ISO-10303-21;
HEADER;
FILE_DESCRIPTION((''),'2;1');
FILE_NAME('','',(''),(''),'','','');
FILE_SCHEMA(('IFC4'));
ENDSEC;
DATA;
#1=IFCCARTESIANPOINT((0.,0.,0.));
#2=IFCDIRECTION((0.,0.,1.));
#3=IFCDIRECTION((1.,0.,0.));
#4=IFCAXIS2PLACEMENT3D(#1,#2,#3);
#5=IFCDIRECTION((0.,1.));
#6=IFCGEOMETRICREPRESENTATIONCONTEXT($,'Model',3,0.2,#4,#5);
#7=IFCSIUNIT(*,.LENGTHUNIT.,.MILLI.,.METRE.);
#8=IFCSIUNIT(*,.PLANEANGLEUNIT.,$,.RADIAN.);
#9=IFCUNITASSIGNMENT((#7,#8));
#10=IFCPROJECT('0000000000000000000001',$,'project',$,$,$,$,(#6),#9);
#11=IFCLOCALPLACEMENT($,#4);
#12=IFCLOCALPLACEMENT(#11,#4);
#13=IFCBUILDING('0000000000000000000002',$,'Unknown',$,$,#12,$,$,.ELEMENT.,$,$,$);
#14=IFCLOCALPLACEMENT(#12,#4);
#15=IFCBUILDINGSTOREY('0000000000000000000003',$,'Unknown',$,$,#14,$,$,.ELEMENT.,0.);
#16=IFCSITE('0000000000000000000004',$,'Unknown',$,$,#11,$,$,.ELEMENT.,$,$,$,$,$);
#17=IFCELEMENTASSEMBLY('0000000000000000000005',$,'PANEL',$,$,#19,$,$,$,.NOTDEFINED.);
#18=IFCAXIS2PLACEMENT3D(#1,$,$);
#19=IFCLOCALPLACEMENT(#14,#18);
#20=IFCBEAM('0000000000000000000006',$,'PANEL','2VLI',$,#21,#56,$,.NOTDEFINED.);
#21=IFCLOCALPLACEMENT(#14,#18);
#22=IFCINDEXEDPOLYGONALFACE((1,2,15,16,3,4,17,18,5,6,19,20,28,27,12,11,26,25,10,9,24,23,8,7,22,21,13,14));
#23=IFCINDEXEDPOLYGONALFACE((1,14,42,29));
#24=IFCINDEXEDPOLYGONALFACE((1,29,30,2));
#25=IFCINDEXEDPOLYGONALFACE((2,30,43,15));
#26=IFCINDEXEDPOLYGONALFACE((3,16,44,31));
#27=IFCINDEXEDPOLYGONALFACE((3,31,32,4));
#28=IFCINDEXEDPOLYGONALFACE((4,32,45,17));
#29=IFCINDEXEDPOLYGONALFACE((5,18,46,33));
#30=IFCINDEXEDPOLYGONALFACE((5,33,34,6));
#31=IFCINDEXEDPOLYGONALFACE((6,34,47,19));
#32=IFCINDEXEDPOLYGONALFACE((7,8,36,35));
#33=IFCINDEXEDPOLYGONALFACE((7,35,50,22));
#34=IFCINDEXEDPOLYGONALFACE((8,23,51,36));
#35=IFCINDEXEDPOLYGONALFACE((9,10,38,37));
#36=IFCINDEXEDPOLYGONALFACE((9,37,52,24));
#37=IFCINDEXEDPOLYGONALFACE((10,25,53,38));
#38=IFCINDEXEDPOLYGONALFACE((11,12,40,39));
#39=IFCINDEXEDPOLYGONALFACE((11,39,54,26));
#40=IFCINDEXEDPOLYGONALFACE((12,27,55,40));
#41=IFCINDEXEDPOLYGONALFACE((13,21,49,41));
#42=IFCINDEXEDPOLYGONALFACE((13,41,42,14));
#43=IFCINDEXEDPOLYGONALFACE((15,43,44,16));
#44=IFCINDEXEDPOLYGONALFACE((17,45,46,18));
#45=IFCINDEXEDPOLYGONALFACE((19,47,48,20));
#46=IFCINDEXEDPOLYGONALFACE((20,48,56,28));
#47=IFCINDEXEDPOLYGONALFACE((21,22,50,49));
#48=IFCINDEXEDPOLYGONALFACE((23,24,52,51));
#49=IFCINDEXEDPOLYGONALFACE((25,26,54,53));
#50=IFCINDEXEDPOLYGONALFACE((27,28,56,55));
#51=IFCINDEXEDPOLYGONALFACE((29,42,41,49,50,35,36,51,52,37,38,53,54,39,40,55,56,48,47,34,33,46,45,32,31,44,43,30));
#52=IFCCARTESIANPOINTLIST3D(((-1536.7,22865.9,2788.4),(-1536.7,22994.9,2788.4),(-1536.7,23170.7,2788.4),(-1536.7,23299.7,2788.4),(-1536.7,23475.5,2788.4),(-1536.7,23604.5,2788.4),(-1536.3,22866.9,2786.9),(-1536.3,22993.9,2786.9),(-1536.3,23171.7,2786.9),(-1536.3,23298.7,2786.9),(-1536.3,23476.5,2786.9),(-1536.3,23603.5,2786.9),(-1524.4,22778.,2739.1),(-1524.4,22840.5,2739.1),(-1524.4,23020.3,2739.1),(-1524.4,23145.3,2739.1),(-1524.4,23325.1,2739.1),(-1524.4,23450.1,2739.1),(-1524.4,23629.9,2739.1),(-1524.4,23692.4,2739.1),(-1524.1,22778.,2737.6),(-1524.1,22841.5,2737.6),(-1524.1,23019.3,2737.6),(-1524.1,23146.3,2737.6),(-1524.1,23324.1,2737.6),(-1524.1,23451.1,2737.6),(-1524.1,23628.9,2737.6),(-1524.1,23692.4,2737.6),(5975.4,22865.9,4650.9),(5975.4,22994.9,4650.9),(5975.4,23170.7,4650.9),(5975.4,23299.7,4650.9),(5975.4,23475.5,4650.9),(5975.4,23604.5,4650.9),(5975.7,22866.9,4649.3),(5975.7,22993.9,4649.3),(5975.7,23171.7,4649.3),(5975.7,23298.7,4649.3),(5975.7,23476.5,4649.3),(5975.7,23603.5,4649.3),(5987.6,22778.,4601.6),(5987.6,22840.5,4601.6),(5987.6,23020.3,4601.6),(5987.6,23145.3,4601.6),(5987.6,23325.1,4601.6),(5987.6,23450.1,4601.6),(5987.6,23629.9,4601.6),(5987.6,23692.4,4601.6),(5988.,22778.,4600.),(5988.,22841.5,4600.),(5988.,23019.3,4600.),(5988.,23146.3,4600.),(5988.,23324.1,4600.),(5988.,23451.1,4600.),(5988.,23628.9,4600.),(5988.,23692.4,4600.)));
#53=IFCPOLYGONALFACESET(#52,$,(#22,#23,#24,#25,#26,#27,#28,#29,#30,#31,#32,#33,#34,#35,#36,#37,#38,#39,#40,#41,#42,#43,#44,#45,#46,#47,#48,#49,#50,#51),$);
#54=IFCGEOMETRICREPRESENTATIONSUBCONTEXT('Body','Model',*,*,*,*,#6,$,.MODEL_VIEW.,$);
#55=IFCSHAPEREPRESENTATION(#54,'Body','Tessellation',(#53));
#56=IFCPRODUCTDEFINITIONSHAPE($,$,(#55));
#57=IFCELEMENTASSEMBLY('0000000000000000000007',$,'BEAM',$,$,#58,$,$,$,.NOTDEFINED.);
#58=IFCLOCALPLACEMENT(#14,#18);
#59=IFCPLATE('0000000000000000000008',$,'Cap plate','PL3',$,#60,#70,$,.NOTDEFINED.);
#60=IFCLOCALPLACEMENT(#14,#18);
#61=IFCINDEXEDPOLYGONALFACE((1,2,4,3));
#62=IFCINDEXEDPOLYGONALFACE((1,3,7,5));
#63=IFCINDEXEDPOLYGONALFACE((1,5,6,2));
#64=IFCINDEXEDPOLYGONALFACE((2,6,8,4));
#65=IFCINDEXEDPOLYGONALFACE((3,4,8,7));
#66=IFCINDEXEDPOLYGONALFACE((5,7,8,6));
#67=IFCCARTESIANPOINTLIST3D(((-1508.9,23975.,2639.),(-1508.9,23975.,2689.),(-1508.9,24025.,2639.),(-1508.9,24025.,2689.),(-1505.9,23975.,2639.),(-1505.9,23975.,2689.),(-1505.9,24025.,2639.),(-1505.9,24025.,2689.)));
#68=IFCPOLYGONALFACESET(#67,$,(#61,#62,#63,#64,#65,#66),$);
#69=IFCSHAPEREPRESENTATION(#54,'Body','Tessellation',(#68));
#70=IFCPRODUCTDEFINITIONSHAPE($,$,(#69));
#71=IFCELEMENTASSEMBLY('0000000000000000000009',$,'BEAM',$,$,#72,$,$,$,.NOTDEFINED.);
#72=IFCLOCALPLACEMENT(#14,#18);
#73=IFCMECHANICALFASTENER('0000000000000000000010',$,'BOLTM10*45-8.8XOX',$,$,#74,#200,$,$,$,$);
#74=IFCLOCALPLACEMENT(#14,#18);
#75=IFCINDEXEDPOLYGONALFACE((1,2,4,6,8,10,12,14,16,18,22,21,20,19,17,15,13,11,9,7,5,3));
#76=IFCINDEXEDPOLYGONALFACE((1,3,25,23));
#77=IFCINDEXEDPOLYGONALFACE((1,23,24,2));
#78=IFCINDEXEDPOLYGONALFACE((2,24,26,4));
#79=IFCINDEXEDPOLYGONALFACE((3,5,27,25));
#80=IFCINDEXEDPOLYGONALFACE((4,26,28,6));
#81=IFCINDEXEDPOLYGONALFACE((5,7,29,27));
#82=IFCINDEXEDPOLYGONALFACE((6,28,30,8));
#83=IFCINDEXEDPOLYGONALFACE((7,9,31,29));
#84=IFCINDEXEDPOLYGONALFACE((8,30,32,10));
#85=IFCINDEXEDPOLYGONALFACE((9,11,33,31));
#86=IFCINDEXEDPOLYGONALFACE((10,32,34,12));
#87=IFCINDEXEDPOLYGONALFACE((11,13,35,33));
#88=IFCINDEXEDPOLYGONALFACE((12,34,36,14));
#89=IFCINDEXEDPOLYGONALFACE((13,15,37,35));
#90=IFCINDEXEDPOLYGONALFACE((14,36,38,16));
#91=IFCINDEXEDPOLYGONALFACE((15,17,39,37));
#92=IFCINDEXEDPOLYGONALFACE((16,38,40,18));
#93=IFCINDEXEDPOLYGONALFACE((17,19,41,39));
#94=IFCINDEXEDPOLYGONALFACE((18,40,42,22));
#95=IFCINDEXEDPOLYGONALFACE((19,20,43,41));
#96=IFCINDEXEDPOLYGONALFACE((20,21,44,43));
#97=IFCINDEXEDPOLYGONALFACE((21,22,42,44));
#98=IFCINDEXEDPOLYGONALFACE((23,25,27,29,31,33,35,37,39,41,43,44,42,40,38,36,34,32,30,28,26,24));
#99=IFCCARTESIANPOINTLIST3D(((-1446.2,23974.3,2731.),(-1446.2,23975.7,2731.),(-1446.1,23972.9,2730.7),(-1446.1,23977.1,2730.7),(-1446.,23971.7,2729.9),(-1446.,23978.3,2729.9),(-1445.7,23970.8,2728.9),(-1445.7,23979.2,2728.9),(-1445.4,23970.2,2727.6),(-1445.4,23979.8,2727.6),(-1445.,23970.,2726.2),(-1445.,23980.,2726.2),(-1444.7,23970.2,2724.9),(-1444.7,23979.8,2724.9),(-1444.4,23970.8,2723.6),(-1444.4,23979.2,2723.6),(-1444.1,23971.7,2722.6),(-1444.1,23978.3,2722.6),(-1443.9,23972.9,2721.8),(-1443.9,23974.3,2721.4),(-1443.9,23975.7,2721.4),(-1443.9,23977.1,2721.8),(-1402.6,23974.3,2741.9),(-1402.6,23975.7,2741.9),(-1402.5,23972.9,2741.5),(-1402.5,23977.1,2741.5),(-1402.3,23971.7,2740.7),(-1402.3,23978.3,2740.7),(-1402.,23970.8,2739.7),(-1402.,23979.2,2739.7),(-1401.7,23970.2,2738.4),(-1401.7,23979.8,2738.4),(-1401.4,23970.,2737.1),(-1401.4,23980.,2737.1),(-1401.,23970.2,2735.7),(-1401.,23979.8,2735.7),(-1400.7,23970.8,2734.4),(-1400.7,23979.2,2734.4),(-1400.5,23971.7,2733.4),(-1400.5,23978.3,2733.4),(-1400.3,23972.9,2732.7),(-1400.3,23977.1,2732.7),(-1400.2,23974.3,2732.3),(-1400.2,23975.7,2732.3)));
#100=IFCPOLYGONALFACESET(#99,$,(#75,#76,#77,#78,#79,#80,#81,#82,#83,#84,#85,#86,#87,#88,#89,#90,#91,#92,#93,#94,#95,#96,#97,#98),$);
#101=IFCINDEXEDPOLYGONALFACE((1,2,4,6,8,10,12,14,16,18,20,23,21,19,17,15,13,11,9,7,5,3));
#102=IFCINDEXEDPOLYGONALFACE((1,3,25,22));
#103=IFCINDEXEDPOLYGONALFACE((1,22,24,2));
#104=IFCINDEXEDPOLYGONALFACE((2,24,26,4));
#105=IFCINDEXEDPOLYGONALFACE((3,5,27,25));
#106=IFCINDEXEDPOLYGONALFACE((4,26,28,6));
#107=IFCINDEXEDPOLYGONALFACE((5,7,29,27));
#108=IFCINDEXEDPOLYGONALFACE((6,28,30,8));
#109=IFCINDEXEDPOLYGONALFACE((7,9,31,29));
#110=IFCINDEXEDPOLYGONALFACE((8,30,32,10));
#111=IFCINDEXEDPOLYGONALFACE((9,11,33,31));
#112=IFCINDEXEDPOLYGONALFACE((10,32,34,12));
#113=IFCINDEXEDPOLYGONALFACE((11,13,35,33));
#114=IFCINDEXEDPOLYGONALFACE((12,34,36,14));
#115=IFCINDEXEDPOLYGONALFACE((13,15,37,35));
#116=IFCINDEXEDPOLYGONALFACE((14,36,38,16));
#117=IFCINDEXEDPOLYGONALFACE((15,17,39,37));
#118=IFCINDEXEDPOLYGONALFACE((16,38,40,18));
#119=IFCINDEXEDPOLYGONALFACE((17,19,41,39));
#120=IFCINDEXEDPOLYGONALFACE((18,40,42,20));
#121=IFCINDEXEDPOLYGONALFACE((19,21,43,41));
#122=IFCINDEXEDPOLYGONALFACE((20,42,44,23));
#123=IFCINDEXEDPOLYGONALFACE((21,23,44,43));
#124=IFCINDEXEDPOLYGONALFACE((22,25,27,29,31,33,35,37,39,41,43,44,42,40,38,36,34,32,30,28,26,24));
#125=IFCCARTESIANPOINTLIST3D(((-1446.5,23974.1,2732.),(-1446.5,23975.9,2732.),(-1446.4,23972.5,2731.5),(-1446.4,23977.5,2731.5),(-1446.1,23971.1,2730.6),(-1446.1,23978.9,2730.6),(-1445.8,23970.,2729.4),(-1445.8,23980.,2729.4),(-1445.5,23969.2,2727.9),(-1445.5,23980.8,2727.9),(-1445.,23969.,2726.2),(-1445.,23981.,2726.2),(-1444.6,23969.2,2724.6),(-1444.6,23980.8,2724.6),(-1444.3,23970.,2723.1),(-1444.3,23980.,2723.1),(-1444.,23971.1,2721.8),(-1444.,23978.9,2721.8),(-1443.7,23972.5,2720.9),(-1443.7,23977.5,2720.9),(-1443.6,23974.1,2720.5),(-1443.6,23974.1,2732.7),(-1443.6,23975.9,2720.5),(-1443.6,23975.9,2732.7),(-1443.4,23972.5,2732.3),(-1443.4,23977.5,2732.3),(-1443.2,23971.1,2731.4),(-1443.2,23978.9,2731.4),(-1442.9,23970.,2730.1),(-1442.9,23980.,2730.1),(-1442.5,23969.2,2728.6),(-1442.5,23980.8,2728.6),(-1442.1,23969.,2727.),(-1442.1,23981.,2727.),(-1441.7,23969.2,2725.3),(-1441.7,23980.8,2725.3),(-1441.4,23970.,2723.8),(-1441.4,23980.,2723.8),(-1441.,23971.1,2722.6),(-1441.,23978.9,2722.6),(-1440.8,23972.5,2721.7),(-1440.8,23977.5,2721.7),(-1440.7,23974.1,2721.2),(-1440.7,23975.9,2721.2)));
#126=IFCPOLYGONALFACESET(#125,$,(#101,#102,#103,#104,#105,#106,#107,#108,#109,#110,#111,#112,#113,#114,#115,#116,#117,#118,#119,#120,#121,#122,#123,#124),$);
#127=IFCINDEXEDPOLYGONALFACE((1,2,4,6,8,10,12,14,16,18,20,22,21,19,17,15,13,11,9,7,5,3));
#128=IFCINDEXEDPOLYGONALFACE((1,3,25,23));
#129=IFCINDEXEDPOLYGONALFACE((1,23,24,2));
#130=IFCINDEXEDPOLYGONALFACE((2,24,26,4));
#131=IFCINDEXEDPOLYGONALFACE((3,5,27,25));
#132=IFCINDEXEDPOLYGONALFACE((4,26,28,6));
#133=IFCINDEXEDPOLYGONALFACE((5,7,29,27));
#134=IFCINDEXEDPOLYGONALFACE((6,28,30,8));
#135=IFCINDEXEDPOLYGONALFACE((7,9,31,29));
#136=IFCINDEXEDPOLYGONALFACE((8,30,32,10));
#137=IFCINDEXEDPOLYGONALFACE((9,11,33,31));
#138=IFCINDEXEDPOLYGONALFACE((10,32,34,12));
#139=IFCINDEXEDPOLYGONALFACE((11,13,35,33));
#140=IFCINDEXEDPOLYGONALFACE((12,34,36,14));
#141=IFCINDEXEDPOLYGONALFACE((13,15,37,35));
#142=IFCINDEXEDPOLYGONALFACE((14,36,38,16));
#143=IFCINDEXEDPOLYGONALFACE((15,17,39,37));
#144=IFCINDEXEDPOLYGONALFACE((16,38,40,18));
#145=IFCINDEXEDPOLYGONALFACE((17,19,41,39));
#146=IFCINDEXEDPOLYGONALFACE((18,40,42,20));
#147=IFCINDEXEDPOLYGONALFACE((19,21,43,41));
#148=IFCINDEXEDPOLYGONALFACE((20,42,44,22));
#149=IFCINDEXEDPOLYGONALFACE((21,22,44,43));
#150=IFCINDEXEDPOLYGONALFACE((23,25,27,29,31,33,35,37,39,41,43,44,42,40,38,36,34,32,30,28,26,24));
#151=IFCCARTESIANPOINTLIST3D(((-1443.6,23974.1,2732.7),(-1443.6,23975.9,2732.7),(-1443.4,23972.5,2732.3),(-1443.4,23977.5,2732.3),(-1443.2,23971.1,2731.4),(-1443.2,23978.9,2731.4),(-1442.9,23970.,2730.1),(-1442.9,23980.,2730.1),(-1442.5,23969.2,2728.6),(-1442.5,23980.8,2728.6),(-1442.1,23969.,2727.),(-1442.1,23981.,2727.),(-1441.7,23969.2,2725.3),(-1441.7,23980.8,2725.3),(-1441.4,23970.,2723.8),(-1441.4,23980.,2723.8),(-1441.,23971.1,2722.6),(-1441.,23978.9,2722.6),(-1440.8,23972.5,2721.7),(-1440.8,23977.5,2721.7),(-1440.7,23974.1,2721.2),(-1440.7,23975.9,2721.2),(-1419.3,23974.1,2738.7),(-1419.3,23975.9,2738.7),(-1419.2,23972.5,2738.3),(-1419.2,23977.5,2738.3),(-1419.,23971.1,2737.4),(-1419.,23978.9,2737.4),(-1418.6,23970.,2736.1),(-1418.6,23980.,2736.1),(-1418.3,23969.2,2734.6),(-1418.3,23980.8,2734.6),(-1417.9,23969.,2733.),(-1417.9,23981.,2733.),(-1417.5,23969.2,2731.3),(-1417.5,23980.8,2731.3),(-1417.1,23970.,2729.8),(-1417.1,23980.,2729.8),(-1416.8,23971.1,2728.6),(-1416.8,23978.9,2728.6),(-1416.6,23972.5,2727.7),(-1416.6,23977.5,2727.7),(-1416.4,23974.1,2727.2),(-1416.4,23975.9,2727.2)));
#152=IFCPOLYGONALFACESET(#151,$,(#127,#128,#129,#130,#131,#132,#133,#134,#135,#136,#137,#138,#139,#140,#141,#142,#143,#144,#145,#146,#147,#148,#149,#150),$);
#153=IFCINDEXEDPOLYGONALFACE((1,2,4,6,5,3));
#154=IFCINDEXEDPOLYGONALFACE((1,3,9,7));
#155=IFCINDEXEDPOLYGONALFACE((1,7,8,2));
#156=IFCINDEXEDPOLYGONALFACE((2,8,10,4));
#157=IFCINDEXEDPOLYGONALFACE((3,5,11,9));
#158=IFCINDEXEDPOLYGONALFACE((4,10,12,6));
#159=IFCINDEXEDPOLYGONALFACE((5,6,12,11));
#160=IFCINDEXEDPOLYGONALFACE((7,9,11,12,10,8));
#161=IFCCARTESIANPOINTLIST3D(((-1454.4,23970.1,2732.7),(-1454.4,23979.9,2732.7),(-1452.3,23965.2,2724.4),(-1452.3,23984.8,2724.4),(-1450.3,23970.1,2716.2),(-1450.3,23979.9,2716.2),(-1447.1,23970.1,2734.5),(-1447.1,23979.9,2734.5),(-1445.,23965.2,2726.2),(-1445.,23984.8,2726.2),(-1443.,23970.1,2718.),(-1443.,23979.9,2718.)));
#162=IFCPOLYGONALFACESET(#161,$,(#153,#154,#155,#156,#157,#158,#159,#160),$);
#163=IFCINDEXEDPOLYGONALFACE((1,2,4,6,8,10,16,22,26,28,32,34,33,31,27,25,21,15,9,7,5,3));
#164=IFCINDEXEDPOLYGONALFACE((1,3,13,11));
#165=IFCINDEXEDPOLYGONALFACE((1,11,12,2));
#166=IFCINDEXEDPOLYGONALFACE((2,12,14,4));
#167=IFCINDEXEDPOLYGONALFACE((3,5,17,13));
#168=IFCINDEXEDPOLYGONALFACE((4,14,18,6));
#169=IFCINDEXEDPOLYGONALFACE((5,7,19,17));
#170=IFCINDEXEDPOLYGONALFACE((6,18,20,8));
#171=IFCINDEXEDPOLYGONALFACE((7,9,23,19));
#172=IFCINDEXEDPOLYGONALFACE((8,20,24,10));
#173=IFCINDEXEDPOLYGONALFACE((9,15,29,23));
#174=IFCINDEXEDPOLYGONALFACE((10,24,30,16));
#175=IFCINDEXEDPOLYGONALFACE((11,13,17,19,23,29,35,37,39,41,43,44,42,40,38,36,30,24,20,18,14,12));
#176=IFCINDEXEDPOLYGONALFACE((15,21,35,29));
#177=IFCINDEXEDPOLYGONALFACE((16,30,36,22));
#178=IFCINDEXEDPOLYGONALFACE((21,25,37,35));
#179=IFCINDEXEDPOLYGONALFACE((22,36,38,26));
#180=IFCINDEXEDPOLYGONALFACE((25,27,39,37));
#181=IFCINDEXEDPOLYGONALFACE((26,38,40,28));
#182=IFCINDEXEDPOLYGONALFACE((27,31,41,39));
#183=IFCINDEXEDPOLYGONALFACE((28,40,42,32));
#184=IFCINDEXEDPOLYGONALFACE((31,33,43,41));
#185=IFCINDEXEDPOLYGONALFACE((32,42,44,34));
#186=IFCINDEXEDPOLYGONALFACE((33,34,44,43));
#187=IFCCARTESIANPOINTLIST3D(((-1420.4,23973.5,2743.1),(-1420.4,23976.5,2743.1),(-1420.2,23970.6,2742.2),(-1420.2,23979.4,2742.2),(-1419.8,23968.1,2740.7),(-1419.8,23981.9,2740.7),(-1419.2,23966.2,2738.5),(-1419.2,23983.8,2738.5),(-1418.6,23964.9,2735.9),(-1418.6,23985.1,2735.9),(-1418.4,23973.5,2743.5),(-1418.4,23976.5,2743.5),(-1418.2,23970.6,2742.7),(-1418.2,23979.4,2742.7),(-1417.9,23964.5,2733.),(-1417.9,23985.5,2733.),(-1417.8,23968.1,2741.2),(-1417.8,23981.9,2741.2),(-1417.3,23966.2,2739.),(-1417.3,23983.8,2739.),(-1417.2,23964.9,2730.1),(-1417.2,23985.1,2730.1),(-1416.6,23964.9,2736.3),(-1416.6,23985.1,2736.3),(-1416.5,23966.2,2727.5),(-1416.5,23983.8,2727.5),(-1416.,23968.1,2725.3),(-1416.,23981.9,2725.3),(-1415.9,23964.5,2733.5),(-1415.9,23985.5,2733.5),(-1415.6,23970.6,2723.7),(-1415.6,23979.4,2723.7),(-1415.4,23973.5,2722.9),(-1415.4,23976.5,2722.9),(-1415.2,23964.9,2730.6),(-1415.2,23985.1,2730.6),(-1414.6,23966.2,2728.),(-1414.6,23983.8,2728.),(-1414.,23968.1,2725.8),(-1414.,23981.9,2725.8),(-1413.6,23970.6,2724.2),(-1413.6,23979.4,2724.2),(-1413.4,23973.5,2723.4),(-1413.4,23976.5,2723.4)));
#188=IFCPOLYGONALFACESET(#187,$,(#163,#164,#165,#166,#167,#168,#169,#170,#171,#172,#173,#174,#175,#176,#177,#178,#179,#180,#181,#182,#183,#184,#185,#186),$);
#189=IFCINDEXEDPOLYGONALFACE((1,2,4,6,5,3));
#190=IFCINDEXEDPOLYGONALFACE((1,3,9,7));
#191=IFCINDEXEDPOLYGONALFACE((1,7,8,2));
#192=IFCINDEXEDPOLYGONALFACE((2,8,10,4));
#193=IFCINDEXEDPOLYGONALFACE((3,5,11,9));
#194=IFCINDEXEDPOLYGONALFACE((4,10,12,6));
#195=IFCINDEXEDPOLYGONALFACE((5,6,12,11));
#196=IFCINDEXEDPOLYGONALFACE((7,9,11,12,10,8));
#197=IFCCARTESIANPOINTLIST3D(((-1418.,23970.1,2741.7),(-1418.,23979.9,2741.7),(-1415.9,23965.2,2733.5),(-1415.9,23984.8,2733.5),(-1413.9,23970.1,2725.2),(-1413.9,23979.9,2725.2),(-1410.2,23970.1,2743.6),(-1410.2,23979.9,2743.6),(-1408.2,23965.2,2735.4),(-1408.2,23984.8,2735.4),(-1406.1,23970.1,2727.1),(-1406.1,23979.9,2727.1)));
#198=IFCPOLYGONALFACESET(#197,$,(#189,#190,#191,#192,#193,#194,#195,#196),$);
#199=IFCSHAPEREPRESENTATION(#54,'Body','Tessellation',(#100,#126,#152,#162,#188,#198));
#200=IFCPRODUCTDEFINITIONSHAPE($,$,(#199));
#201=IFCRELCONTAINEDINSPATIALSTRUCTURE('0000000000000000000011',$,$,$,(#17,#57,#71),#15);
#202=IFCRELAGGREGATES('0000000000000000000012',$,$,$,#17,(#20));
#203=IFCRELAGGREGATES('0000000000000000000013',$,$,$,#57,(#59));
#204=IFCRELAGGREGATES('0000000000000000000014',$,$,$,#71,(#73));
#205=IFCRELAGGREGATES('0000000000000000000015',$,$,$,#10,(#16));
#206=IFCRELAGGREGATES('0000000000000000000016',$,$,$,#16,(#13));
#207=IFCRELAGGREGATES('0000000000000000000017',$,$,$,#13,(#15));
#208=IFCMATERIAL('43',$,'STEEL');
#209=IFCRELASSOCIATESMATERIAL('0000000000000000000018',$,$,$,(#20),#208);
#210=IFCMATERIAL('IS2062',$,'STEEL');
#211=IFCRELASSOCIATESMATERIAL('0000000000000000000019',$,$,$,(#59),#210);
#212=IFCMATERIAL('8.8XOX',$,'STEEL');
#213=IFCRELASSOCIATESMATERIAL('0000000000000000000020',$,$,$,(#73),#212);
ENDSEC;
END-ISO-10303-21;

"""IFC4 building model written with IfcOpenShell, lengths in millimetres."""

from ifc_helpers import new_model, si_unit, direction, frame, origin_with_axes, place, context, subcontext, project, spatial, line, arc, indexed_curve, outline, extrude, source, transform, mapped, material, element, aggregate, save


model = new_model("IFC4")

# Units and contexts
model_context = context("Model", 3, precision=0.2, world=origin_with_axes(), true_north=direction((0.0, 1.0)))
body_context = subcontext(model_context, "Body", "Model", "MODEL_VIEW")
ifc_project = project(units=[si_unit("LENGTHUNIT", "METRE", prefix="MILLI"), si_unit("PLANEANGLEUNIT", "RADIAN")], contexts=[model_context])

# Site, building, storey
site_placement = place(None, origin_with_axes())
site = spatial("IfcSite", under=ifc_project, at=site_placement, Name="Unknown", CompositionType="ELEMENT")
building_placement = place(site_placement, origin_with_axes())
building = spatial("IfcBuilding", under=site, at=building_placement, Name="Unknown", CompositionType="ELEMENT")
storey_placement = place(building_placement, origin_with_axes())
storey = spatial("IfcBuildingStorey", under=building, at=storey_placement, Name="Unknown", CompositionType="ELEMENT", Elevation=0.0)

# Shared definitions
ifc_material_1 = material(Name="IS2062", Category="STEEL")

# Element assembly, beam
ifc_material_2 = material(Name="43", Category="STEEL")
assembly_1_placement = place(storey_placement, frame((-1530.4, 23235.2, 2763.0), z_axis=(0.0, -1.0, 0.0), x_axis=(0.970613, 0.0, 0.240648)))
assembly_1 = element("IfcElementAssembly", 1, at=assembly_1_placement, inside=storey, Name="PANEL", PredefinedType="NOTDEFINED")
beam_1_placement = place(assembly_1_placement, origin_with_axes())
beam_1 = element("IfcBeam", 2, at=beam_1_placement, material=ifc_material_2, Name="PANEL", Description="2VLI", PredefinedType="NOTDEFINED", context=body_context, shape_type="SolidModel", body=[
    extrude(outline(indexed_curve([(457.2, -26.2), (457.2, -24.6), (394.7, -24.6), (369.3, 26.2), (240.3, 26.2), (214.9, -24.6), (89.9, -24.6), (64.5, 26.2), (-64.5, 26.2), (-89.9, -24.6), (-214.9, -24.6), (-240.3, 26.2), (-369.3, 26.2), (-394.7, -24.6), (-457.2, -24.6), (-457.2, -26.2), (-393.7, -26.2), (-368.3, 24.6), (-241.3, 24.6), (-215.9, -26.2), (-88.9, -26.2), (-63.5, 24.6), (63.5, 24.6), (88.9, -26.2), (215.9, -26.2), (241.3, 24.6), (368.3, 24.6), (393.7, -26.2)], segments=[line(1, 2, 3, 4, 5, 6, 7, 8, 9, 10, 11, 12, 13, 14, 15, 16, 17, 18, 19, 20, 21, 22, 23, 24, 25, 26, 27, 28, 1)])), frame((0.0, 0.0, 0.0), z_axis=(-1.0, 0.0, 0.0), x_axis=(0.0, 0.0, 1.0)), (0.0, 0.0, -1.0), 7739.5),
])
aggregate(assembly_1, [beam_1])

# Element assembly, plate
assembly_2_placement = place(storey_placement, frame((-1505.9, 24000.0, 2664.0), z_axis=(0.0, -1.0, 0.0), x_axis=(1.0, 0.0, 0.0)))
assembly_2 = element("IfcElementAssembly", 3, at=assembly_2_placement, inside=storey, Name="BEAM", PredefinedType="NOTDEFINED")
plate_placement = place(assembly_2_placement, frame((-1.5, 25.0, 25.0), z_axis=(-1.0, 0.0, 0.0), x_axis=(0.0, 0.0, -1.0)))
plate = element("IfcPlate", 4, at=plate_placement, material=ifc_material_1, Name="Cap plate", Description="PL3", PredefinedType="NOTDEFINED", context=body_context, shape_type="SolidModel", body=[
    extrude(outline(indexed_curve([(0.0, 0.0), (50.0, 0.0), (50.0, 50.0), (0.0, 50.0)], segments=[line(1, 2, 3, 4, 1)])), frame((0.0, 0.0, 1.5), z_axis=(0.0, 0.0, 1.0), x_axis=(1.0, 0.0, 0.0)), (0.0, 0.0, -1.0), 3.0),
])
aggregate(assembly_2, [plate])

# Element assembly, mechanical fastener
assembly_3_placement = place(storey_placement, frame((-1431.2, 18000.0, 2734.8), z_axis=(0.970613, 0.0, 0.240648), x_axis=(0.0, 1.0, 0.0)))
assembly_3 = element("IfcElementAssembly", 5, at=assembly_3_placement, inside=storey, Name="BEAM", PredefinedType="NOTDEFINED")
ifc_material_3 = material(Name="8.8XOX", Category="STEEL")
shared_shape_1 = source(origin_with_axes(), body_context, "Body", "SweptSolid", [
    extrude(outline(indexed_curve([(5.0, 0.0), (0.0, 5.0), (-5.0, 0.0), (0.0, -5.0)], segments=[arc(1, 2, 3), arc(3, 4, 1)])), frame((0.0, 0.0, 3.8), z_axis=(0.0, 0.0, -1.0), x_axis=(0.0, 1.0, 0.0)), (0.0, 0.0, 1.0), 45.0),
    extrude(outline(indexed_curve([(6.0, 0.0), (0.0, 6.0), (-6.0, 0.0), (0.0, -6.0)], segments=[arc(1, 2, 3), arc(3, 4, 1)])), frame((0.0, 0.0, 3.8), z_axis=(0.0, 0.0, -1.0), x_axis=(0.0, 1.0, 0.0)), (0.0, 0.0, 1.0), 3.0),
    extrude(outline(indexed_curve([(6.0, 0.0), (0.0, 6.0), (-6.0, 0.0), (0.0, -6.0)], segments=[arc(1, 2, 3), arc(3, 4, 1)])), frame((0.0, 0.0, 0.8), z_axis=(0.0, 0.0, -1.0), x_axis=(0.0, 1.0, 0.0)), (0.0, 0.0, 1.0), 25.0),
    extrude(outline(indexed_curve([(9.8, 0.0), (4.9, 8.5), (-4.9, 8.5), (-9.8, 0.0), (-4.9, -8.5), (4.9, -8.5)], segments=[line(1, 2, 3, 4, 5, 6, 1)])), frame((0.0, 0.0, 11.2), z_axis=(0.0, 0.0, -1.0), x_axis=(0.0, 1.0, 0.0)), (0.0, 0.0, 1.0), 7.5),
    extrude(outline(indexed_curve([(10.5, 0.0), (0.0, 10.5), (-10.5, 0.0), (0.0, -10.5)], segments=[arc(1, 2, 3), arc(3, 4, 1)])), frame((0.0, 0.0, -24.2), z_axis=(0.0, 0.0, -1.0), x_axis=(0.0, 1.0, 0.0)), (0.0, 0.0, 1.0), 2.0),
    extrude(outline(indexed_curve([(9.8, 0.0), (4.9, 8.5), (-4.9, 8.5), (-9.8, 0.0), (-4.9, -8.5), (4.9, -8.5)], segments=[line(1, 2, 3, 4, 5, 6, 1)])), frame((0.0, 0.0, -26.2), z_axis=(0.0, 0.0, -1.0), x_axis=(0.0, 1.0, 0.0)), (0.0, 0.0, 1.0), 8.0),
])
mechanical_fastener_1_placement = place(assembly_3_placement, frame((5975.0, -5.0, -11.8), z_axis=(0.0, 0.0, -1.0), x_axis=(0.0, 1.0, 0.0)))
mechanical_fastener_1 = element("IfcMechanicalFastener", 6, at=mechanical_fastener_1_placement, material=ifc_material_3, Name="BOLTM10*45-8.8XOX", context=body_context, shape_type="MappedRepresentation", body=[
    mapped(shared_shape_1, transform((0.0, 0.0, 0.0))),
])
aggregate(assembly_3, [mechanical_fastener_1])

save(model, "model.ifc")
